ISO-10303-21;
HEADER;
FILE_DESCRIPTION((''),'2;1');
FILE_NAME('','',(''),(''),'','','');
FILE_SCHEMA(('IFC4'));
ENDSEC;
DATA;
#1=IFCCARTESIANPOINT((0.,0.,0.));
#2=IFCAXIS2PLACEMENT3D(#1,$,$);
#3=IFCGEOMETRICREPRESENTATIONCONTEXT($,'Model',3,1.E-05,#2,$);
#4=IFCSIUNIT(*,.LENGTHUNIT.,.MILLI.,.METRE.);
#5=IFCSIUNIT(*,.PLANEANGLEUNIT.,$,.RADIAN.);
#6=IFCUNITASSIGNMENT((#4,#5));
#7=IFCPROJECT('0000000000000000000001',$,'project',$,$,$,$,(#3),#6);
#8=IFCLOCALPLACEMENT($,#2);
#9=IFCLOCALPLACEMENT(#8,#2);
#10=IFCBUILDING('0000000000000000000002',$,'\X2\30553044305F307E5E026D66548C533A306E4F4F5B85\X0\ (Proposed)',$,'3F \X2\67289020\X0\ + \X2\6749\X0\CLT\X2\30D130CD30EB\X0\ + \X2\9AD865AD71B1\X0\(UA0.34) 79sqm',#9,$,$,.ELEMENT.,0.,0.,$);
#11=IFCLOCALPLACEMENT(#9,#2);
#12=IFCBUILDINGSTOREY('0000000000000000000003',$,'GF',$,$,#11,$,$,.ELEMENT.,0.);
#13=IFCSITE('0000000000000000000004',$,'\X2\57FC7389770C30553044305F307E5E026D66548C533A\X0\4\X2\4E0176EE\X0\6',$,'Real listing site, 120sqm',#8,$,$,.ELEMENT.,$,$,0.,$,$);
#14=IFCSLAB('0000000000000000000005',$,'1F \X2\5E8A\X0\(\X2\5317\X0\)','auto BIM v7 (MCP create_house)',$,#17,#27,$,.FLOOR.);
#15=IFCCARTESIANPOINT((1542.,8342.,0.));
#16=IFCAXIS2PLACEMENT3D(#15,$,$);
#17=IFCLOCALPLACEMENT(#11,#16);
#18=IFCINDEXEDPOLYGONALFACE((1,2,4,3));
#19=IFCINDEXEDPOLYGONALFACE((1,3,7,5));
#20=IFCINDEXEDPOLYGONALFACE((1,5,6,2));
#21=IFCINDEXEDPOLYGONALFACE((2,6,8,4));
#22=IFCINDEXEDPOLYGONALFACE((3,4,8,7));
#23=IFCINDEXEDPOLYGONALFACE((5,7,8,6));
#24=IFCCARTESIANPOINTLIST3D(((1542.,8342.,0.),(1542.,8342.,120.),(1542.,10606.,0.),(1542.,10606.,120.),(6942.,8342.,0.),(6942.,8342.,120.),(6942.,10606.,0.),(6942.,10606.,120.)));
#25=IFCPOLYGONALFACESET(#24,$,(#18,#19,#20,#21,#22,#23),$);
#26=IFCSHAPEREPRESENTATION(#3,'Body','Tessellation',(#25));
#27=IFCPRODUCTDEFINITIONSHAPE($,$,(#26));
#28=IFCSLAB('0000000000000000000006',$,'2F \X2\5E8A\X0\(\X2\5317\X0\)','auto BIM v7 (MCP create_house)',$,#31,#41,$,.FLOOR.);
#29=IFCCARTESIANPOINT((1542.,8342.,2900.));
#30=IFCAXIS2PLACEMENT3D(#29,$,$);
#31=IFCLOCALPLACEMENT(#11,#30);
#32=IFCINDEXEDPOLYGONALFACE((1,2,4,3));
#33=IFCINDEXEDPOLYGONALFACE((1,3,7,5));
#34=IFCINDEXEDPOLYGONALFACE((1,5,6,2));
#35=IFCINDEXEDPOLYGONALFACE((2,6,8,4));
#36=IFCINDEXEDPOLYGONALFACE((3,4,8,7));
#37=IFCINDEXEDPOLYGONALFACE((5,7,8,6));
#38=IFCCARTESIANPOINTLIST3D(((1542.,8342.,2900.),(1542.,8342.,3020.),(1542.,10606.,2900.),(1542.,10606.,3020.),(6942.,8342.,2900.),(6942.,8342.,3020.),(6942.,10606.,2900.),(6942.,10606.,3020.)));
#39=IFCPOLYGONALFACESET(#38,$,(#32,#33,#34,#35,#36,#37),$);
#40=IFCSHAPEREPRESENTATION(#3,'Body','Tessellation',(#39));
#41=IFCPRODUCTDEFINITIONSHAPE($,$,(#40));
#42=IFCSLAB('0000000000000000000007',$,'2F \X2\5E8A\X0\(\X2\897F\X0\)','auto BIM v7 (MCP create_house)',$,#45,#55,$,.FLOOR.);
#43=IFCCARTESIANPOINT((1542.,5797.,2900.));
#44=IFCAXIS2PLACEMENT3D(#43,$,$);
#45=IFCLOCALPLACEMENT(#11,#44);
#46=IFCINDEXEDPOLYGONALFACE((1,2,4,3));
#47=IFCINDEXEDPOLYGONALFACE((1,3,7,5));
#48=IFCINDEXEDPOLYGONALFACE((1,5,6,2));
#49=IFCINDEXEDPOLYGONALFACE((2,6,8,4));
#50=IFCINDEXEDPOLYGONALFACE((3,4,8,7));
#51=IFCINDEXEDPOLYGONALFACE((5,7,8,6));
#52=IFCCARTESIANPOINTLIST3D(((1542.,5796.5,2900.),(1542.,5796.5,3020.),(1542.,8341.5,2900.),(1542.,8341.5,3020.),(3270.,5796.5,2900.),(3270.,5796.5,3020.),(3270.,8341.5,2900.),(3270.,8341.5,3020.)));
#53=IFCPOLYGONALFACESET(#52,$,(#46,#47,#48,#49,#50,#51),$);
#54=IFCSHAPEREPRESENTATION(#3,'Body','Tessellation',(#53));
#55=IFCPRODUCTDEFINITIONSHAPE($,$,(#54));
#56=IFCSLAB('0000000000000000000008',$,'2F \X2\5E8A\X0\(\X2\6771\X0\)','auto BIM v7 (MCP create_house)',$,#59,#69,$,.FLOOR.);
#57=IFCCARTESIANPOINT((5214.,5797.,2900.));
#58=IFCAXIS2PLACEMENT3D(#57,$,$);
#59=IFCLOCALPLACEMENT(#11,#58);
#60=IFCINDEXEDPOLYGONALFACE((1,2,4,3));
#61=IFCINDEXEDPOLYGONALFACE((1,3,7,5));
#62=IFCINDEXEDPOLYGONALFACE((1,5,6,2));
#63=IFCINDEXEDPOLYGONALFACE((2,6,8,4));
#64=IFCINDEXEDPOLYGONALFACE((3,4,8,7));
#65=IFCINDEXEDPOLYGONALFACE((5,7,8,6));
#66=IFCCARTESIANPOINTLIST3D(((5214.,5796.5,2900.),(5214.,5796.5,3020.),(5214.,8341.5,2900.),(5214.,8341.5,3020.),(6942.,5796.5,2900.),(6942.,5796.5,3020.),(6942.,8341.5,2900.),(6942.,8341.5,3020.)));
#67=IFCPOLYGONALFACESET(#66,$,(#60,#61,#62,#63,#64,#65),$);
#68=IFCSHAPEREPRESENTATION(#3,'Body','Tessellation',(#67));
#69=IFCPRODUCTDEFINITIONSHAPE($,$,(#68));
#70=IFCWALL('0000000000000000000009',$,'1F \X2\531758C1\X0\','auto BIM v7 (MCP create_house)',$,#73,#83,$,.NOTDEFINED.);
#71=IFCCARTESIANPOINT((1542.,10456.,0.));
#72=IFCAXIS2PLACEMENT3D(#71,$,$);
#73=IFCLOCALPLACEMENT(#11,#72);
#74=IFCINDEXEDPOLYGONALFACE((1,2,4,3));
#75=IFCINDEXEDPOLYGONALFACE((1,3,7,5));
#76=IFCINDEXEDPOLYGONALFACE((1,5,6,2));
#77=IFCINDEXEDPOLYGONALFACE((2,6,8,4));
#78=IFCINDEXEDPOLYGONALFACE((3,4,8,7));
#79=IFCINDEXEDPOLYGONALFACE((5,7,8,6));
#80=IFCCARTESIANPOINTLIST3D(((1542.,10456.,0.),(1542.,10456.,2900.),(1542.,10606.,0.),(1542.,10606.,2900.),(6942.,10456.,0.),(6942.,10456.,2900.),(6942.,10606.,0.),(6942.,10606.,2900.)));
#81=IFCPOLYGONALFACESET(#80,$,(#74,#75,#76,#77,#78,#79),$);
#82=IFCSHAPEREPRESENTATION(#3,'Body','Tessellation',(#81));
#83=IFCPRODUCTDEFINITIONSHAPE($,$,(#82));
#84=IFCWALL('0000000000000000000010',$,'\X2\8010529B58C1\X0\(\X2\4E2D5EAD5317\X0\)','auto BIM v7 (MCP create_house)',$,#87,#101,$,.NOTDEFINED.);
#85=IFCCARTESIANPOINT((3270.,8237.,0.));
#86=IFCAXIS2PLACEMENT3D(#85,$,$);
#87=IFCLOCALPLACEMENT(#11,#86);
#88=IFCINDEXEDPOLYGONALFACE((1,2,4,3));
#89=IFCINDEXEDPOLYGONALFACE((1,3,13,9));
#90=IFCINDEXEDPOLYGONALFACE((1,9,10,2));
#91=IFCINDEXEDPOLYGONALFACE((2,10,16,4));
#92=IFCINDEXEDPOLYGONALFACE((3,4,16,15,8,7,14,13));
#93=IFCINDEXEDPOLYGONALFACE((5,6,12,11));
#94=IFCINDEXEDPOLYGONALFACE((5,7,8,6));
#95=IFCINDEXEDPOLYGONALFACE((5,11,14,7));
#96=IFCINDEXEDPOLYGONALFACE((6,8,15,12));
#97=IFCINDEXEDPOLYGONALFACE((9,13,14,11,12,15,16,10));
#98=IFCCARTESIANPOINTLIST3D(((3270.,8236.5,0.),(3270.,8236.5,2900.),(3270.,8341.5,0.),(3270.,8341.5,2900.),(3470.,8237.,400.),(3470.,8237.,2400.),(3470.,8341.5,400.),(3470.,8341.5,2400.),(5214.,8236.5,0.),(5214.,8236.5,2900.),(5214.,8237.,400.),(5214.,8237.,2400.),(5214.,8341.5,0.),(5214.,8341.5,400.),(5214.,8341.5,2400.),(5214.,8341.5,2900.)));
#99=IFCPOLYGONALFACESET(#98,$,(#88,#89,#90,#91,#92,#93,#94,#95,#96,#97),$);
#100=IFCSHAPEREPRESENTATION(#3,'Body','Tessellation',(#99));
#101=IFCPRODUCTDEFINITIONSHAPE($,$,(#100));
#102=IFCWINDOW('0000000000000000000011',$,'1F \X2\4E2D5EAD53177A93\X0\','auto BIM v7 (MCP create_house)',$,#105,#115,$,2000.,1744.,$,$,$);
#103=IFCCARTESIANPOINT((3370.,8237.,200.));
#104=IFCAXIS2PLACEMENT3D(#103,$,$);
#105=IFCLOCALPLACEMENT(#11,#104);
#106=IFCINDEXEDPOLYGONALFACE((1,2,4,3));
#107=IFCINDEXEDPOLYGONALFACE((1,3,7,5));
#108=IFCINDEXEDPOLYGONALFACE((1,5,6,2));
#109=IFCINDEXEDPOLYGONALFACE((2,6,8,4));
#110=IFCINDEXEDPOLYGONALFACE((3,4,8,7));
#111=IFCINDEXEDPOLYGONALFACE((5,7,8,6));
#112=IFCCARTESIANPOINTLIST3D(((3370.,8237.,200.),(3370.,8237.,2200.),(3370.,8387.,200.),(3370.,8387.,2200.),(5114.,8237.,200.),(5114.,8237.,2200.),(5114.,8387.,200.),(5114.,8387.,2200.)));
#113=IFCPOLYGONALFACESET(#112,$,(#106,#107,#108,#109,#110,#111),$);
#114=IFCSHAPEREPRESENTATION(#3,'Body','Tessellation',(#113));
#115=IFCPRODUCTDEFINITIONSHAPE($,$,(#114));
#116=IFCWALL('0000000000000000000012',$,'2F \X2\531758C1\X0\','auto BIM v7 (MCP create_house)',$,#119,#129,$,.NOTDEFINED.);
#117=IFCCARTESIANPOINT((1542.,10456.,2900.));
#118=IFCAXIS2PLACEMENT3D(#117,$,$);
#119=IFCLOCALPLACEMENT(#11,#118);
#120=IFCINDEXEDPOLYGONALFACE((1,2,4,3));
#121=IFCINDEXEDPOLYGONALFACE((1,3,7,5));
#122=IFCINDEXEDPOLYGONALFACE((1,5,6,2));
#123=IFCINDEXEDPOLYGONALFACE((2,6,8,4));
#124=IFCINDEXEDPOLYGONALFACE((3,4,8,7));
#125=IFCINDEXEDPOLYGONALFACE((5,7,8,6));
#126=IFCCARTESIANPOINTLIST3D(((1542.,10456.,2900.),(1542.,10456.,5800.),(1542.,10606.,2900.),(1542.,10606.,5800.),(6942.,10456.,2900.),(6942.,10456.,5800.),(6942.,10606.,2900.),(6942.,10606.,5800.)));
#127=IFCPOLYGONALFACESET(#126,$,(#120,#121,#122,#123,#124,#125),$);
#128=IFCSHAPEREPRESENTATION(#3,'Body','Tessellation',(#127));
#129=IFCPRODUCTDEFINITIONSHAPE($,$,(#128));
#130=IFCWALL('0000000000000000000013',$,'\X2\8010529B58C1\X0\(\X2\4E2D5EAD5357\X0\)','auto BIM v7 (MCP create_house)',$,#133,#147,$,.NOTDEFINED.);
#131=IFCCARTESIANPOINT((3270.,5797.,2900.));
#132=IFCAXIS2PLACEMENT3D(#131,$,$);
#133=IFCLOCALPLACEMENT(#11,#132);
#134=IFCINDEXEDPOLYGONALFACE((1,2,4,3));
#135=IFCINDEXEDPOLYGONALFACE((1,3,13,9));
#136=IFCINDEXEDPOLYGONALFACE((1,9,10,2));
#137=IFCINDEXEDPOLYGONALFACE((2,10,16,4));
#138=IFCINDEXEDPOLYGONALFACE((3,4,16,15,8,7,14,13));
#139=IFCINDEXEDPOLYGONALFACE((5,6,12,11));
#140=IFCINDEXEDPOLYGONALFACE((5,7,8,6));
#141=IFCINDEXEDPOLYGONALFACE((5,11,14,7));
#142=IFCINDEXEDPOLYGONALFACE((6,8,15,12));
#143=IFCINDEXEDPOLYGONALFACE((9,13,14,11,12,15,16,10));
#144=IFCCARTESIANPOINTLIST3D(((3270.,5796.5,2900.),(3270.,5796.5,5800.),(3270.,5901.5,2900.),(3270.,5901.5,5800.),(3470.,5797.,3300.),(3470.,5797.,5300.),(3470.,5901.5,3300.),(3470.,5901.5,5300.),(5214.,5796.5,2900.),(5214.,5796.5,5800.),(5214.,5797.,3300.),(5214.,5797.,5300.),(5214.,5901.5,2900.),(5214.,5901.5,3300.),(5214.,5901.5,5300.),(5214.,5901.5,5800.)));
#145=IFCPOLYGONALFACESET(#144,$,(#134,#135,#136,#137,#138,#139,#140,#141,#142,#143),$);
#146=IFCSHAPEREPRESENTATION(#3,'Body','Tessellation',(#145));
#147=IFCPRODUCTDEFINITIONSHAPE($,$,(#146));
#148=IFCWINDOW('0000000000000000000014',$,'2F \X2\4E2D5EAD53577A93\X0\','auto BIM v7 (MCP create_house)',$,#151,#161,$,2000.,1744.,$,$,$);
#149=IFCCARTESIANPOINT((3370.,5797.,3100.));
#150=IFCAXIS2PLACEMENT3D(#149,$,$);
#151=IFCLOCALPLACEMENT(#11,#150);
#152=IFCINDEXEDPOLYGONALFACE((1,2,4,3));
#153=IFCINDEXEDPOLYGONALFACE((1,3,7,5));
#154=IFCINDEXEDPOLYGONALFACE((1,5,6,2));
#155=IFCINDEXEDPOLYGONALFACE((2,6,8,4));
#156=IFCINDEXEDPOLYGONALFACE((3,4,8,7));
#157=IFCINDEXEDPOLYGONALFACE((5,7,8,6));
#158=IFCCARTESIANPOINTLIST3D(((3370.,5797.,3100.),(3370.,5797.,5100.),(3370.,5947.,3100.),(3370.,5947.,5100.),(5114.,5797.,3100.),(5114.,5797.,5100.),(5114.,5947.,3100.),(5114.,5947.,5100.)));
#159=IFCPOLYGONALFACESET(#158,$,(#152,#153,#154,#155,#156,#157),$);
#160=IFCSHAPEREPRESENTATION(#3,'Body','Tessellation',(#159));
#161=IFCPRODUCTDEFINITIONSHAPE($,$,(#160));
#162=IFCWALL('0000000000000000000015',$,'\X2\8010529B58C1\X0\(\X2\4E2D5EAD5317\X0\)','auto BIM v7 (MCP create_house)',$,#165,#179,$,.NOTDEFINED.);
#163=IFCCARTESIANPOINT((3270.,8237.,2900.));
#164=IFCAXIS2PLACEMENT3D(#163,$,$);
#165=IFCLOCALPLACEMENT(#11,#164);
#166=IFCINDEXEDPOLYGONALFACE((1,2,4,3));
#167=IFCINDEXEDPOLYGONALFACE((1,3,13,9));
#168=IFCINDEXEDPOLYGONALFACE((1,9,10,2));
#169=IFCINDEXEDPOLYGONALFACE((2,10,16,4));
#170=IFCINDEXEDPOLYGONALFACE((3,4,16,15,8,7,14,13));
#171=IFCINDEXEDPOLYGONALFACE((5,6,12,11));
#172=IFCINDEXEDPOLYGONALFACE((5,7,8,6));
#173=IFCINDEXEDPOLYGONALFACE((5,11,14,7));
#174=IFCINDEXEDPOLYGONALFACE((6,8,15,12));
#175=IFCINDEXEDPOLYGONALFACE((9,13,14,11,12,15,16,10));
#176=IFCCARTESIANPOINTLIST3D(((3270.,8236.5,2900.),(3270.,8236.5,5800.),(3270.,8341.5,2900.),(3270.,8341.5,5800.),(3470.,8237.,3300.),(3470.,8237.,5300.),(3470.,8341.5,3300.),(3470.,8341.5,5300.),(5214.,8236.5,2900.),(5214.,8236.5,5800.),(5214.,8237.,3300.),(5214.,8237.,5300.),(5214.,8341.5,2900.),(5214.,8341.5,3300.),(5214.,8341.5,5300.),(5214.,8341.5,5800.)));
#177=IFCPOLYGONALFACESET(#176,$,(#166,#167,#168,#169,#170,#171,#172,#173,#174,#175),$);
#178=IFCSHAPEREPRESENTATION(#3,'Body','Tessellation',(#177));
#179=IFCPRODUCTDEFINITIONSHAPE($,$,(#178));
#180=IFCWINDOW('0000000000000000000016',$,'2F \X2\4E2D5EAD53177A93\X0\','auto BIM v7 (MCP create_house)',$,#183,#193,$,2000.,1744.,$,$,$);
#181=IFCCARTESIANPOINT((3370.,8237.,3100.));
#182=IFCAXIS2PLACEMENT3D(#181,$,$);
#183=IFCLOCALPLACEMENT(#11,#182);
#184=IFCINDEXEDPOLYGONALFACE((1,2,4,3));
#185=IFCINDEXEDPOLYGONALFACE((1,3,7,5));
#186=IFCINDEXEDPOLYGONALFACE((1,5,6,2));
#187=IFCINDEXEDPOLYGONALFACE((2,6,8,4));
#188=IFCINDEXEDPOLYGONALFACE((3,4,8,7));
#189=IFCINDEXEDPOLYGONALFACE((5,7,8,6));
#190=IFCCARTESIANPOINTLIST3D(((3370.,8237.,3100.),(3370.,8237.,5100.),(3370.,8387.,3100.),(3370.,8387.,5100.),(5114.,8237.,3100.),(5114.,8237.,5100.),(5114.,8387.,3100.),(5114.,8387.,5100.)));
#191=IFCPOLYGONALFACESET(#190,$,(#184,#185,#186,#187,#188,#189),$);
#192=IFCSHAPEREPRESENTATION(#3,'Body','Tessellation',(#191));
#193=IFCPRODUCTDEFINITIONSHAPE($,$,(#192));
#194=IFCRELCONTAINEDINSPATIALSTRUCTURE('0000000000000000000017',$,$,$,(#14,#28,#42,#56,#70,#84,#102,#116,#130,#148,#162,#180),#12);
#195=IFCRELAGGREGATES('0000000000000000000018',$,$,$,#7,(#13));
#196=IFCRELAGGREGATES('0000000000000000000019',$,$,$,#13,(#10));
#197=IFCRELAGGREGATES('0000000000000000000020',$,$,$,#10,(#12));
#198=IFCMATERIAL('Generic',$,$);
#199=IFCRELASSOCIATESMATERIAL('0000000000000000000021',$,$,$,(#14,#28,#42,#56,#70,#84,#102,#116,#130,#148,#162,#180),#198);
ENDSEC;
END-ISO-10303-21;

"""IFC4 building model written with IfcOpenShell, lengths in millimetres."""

from ifc_helpers import new_model, si_unit, frame, frame_2d, origin, place, context, project, spatial, rectangle, extrude, material, element, fill, save


model = new_model("IFC4")

# Units and contexts
model_context = context("Model", 3, precision=1e-05, world=origin())
ifc_project = project(units=[si_unit("LENGTHUNIT", "METRE", prefix="MILLI"), si_unit("PLANEANGLEUNIT", "RADIAN")], contexts=[model_context])

# Site, building, storey
site_placement = place(None, origin())
site = spatial("IfcSite", under=ifc_project, at=site_placement, Name="埼玉県さいたま市浦和区4丁目6", ObjectType="Real listing site, 120sqm", CompositionType="ELEMENT", RefElevation=0.0)
building_placement = place(site_placement, origin())
building = spatial("IfcBuilding", under=site, at=building_placement, Name="さいたま市浦和区の住宅 (Proposed)", ObjectType="3F 木造 + 杉CLTパネル + 高断熱(UA0.34) 79sqm", CompositionType="ELEMENT", ElevationOfRefHeight=0.0, ElevationOfTerrain=0.0)
storey_placement = place(building_placement, origin())
storey = spatial("IfcBuildingStorey", under=building, at=storey_placement, Name="GF", CompositionType="ELEMENT", Elevation=0.0)

# Slabs
ifc_material = material(Name="Generic")
slab_1_placement = place(storey_placement, frame((1542.0, 8342.0, 0.0)))
element("IfcSlab", 1, at=slab_1_placement, inside=storey, material=ifc_material, Name="1F 床(北)", Description="auto BIM v7 (MCP create_house)", PredefinedType="FLOOR", context=model_context, shape_type="SweptSolid", body=[
    extrude(rectangle(XDim=5400.0, YDim=2264.0, at=frame_2d((2700.0, 1132.0))), frame((1542.0, 8342.0, 0.0)), (0.0, 0.0, 1.0), 120.0),
])
slab_2_placement = place(storey_placement, frame((1542.0, 8342.0, 2900.0)))
element("IfcSlab", 2, at=slab_2_placement, inside=storey, material=ifc_material, Name="2F 床(北)", Description="auto BIM v7 (MCP create_house)", PredefinedType="FLOOR", context=model_context, shape_type="SweptSolid", body=[
    extrude(rectangle(XDim=5400.0, YDim=2264.0, at=frame_2d((2700.0, 1132.0))), frame((1542.0, 8342.0, 2900.0)), (0.0, 0.0, 1.0), 120.0),
])
slab_3_placement = place(storey_placement, frame((1542.0, 5797.0, 2900.0)))
element("IfcSlab", 3, at=slab_3_placement, inside=storey, material=ifc_material, Name="2F 床(西)", Description="auto BIM v7 (MCP create_house)", PredefinedType="FLOOR", context=model_context, shape_type="SweptSolid", body=[
    extrude(rectangle(XDim=1728.0, YDim=2545.0, at=frame_2d((864.0, 1272.0))), frame((1542.0, 5797.0, 2900.0)), (0.0, 0.0, 1.0), 120.0),
])
slab_4_placement = place(storey_placement, frame((5214.0, 5797.0, 2900.0)))
element("IfcSlab", 4, at=slab_4_placement, inside=storey, material=ifc_material, Name="2F 床(東)", Description="auto BIM v7 (MCP create_house)", PredefinedType="FLOOR", context=model_context, shape_type="SweptSolid", body=[
    extrude(rectangle(XDim=1728.0, YDim=2545.0, at=frame_2d((864.0, 1272.0))), frame((5214.0, 5797.0, 2900.0)), (0.0, 0.0, 1.0), 120.0),
])

# Wall
wall_1_placement = place(storey_placement, frame((1542.0, 10456.0, 0.0)))
element("IfcWall", 5, at=wall_1_placement, inside=storey, material=ifc_material, Name="1F 北壁", Description="auto BIM v7 (MCP create_house)", PredefinedType="NOTDEFINED", context=model_context, shape_type="SweptSolid", body=[
    extrude(rectangle(XDim=5400.0, YDim=150.0, at=frame_2d((2700.0, 75.0))), frame((1542.0, 10456.0, 0.0)), (0.0, 0.0, 1.0), 2900.0),
])

# Wall, opening, window
wall_2_placement = place(storey_placement, frame((3270.0, 8237.0, 0.0)))
wall_2 = element("IfcWall", 6, at=wall_2_placement, inside=storey, material=ifc_material, Name="耐力壁(中庭北)", Description="auto BIM v7 (MCP create_house)", PredefinedType="NOTDEFINED", context=model_context, shape_type="SweptSolid", body=[
    extrude(rectangle(XDim=1944.0, YDim=105.0, at=frame_2d((972.0, 52.0))), frame((3270.0, 8237.0, 0.0)), (0.0, 0.0, 1.0), 2900.0),
])
opening_1_placement = place(storey_placement, frame((3370.0, 8237.0, 200.0)))
opening_1 = element("IfcOpeningElement", 7, at=opening_1_placement, cuts=wall_2, PredefinedType="NOTDEFINED", context=model_context, shape_type="SweptSolid", body=[
    extrude(rectangle(XDim=1744.0, YDim=150.0, at=frame_2d((872.0, 75.0))), frame((3370.0, 8237.0, 200.0)), (0.0, 0.0, 1.0), 2000.0),
])
window_1_placement = place(storey_placement, frame((3370.0, 8237.0, 200.0)))
window_1 = element("IfcWindow", 8, at=window_1_placement, inside=storey, material=ifc_material, Name="1F 中庭北窓", Description="auto BIM v7 (MCP create_house)", OverallHeight=2000.0, OverallWidth=1744.0, context=model_context, shape_type="SweptSolid", body=[
    extrude(rectangle(XDim=1744.0, YDim=150.0, at=frame_2d((872.0, 75.0))), frame((3370.0, 8237.0, 200.0)), (0.0, 0.0, 1.0), 2000.0),
])
fill(opening_1, window_1)

# Wall
wall_3_placement = place(storey_placement, frame((1542.0, 10456.0, 2900.0)))
element("IfcWall", 9, at=wall_3_placement, inside=storey, material=ifc_material, Name="2F 北壁", Description="auto BIM v7 (MCP create_house)", PredefinedType="NOTDEFINED", context=model_context, shape_type="SweptSolid", body=[
    extrude(rectangle(XDim=5400.0, YDim=150.0, at=frame_2d((2700.0, 75.0))), frame((1542.0, 10456.0, 2900.0)), (0.0, 0.0, 1.0), 2900.0),
])

# Walls, openings, windows
wall_4_placement = place(storey_placement, frame((3270.0, 5797.0, 2900.0)))
wall_4 = element("IfcWall", 10, at=wall_4_placement, inside=storey, material=ifc_material, Name="耐力壁(中庭南)", Description="auto BIM v7 (MCP create_house)", PredefinedType="NOTDEFINED", context=model_context, shape_type="SweptSolid", body=[
    extrude(rectangle(XDim=1944.0, YDim=105.0, at=frame_2d((972.0, 52.0))), frame((3270.0, 5797.0, 2900.0)), (0.0, 0.0, 1.0), 2900.0),
])
opening_2_placement = place(storey_placement, frame((3370.0, 5797.0, 3100.0)))
opening_2 = element("IfcOpeningElement", 11, at=opening_2_placement, cuts=wall_4, PredefinedType="NOTDEFINED", context=model_context, shape_type="SweptSolid", body=[
    extrude(rectangle(XDim=1744.0, YDim=150.0, at=frame_2d((872.0, 75.0))), frame((3370.0, 5797.0, 3100.0)), (0.0, 0.0, 1.0), 2000.0),
])
window_2_placement = place(storey_placement, frame((3370.0, 5797.0, 3100.0)))
window_2 = element("IfcWindow", 12, at=window_2_placement, inside=storey, material=ifc_material, Name="2F 中庭南窓", Description="auto BIM v7 (MCP create_house)", OverallHeight=2000.0, OverallWidth=1744.0, context=model_context, shape_type="SweptSolid", body=[
    extrude(rectangle(XDim=1744.0, YDim=150.0, at=frame_2d((872.0, 75.0))), frame((3370.0, 5797.0, 3100.0)), (0.0, 0.0, 1.0), 2000.0),
])
fill(opening_2, window_2)
wall_5_placement = place(storey_placement, frame((3270.0, 8237.0, 2900.0)))
wall_5 = element("IfcWall", 13, at=wall_5_placement, inside=storey, material=ifc_material, Name="耐力壁(中庭北)", Description="auto BIM v7 (MCP create_house)", PredefinedType="NOTDEFINED", context=model_context, shape_type="SweptSolid", body=[
    extrude(rectangle(XDim=1944.0, YDim=105.0, at=frame_2d((972.0, 52.0))), frame((3270.0, 8237.0, 2900.0)), (0.0, 0.0, 1.0), 2900.0),
])
opening_3_placement = place(storey_placement, frame((3370.0, 8237.0, 3100.0)))
opening_3 = element("IfcOpeningElement", 14, at=opening_3_placement, cuts=wall_5, PredefinedType="NOTDEFINED", context=model_context, shape_type="SweptSolid", body=[
    extrude(rectangle(XDim=1744.0, YDim=150.0, at=frame_2d((872.0, 75.0))), frame((3370.0, 8237.0, 3100.0)), (0.0, 0.0, 1.0), 2000.0),
])
window_3_placement = place(storey_placement, frame((3370.0, 8237.0, 3100.0)))
window_3 = element("IfcWindow", 15, at=window_3_placement, inside=storey, material=ifc_material, Name="2F 中庭北窓", Description="auto BIM v7 (MCP create_house)", OverallHeight=2000.0, OverallWidth=1744.0, context=model_context, shape_type="SweptSolid", body=[
    extrude(rectangle(XDim=1744.0, YDim=150.0, at=frame_2d((872.0, 75.0))), frame((3370.0, 8237.0, 3100.0)), (0.0, 0.0, 1.0), 2000.0),
])
fill(opening_3, window_3)

save(model, "model.ifc")
